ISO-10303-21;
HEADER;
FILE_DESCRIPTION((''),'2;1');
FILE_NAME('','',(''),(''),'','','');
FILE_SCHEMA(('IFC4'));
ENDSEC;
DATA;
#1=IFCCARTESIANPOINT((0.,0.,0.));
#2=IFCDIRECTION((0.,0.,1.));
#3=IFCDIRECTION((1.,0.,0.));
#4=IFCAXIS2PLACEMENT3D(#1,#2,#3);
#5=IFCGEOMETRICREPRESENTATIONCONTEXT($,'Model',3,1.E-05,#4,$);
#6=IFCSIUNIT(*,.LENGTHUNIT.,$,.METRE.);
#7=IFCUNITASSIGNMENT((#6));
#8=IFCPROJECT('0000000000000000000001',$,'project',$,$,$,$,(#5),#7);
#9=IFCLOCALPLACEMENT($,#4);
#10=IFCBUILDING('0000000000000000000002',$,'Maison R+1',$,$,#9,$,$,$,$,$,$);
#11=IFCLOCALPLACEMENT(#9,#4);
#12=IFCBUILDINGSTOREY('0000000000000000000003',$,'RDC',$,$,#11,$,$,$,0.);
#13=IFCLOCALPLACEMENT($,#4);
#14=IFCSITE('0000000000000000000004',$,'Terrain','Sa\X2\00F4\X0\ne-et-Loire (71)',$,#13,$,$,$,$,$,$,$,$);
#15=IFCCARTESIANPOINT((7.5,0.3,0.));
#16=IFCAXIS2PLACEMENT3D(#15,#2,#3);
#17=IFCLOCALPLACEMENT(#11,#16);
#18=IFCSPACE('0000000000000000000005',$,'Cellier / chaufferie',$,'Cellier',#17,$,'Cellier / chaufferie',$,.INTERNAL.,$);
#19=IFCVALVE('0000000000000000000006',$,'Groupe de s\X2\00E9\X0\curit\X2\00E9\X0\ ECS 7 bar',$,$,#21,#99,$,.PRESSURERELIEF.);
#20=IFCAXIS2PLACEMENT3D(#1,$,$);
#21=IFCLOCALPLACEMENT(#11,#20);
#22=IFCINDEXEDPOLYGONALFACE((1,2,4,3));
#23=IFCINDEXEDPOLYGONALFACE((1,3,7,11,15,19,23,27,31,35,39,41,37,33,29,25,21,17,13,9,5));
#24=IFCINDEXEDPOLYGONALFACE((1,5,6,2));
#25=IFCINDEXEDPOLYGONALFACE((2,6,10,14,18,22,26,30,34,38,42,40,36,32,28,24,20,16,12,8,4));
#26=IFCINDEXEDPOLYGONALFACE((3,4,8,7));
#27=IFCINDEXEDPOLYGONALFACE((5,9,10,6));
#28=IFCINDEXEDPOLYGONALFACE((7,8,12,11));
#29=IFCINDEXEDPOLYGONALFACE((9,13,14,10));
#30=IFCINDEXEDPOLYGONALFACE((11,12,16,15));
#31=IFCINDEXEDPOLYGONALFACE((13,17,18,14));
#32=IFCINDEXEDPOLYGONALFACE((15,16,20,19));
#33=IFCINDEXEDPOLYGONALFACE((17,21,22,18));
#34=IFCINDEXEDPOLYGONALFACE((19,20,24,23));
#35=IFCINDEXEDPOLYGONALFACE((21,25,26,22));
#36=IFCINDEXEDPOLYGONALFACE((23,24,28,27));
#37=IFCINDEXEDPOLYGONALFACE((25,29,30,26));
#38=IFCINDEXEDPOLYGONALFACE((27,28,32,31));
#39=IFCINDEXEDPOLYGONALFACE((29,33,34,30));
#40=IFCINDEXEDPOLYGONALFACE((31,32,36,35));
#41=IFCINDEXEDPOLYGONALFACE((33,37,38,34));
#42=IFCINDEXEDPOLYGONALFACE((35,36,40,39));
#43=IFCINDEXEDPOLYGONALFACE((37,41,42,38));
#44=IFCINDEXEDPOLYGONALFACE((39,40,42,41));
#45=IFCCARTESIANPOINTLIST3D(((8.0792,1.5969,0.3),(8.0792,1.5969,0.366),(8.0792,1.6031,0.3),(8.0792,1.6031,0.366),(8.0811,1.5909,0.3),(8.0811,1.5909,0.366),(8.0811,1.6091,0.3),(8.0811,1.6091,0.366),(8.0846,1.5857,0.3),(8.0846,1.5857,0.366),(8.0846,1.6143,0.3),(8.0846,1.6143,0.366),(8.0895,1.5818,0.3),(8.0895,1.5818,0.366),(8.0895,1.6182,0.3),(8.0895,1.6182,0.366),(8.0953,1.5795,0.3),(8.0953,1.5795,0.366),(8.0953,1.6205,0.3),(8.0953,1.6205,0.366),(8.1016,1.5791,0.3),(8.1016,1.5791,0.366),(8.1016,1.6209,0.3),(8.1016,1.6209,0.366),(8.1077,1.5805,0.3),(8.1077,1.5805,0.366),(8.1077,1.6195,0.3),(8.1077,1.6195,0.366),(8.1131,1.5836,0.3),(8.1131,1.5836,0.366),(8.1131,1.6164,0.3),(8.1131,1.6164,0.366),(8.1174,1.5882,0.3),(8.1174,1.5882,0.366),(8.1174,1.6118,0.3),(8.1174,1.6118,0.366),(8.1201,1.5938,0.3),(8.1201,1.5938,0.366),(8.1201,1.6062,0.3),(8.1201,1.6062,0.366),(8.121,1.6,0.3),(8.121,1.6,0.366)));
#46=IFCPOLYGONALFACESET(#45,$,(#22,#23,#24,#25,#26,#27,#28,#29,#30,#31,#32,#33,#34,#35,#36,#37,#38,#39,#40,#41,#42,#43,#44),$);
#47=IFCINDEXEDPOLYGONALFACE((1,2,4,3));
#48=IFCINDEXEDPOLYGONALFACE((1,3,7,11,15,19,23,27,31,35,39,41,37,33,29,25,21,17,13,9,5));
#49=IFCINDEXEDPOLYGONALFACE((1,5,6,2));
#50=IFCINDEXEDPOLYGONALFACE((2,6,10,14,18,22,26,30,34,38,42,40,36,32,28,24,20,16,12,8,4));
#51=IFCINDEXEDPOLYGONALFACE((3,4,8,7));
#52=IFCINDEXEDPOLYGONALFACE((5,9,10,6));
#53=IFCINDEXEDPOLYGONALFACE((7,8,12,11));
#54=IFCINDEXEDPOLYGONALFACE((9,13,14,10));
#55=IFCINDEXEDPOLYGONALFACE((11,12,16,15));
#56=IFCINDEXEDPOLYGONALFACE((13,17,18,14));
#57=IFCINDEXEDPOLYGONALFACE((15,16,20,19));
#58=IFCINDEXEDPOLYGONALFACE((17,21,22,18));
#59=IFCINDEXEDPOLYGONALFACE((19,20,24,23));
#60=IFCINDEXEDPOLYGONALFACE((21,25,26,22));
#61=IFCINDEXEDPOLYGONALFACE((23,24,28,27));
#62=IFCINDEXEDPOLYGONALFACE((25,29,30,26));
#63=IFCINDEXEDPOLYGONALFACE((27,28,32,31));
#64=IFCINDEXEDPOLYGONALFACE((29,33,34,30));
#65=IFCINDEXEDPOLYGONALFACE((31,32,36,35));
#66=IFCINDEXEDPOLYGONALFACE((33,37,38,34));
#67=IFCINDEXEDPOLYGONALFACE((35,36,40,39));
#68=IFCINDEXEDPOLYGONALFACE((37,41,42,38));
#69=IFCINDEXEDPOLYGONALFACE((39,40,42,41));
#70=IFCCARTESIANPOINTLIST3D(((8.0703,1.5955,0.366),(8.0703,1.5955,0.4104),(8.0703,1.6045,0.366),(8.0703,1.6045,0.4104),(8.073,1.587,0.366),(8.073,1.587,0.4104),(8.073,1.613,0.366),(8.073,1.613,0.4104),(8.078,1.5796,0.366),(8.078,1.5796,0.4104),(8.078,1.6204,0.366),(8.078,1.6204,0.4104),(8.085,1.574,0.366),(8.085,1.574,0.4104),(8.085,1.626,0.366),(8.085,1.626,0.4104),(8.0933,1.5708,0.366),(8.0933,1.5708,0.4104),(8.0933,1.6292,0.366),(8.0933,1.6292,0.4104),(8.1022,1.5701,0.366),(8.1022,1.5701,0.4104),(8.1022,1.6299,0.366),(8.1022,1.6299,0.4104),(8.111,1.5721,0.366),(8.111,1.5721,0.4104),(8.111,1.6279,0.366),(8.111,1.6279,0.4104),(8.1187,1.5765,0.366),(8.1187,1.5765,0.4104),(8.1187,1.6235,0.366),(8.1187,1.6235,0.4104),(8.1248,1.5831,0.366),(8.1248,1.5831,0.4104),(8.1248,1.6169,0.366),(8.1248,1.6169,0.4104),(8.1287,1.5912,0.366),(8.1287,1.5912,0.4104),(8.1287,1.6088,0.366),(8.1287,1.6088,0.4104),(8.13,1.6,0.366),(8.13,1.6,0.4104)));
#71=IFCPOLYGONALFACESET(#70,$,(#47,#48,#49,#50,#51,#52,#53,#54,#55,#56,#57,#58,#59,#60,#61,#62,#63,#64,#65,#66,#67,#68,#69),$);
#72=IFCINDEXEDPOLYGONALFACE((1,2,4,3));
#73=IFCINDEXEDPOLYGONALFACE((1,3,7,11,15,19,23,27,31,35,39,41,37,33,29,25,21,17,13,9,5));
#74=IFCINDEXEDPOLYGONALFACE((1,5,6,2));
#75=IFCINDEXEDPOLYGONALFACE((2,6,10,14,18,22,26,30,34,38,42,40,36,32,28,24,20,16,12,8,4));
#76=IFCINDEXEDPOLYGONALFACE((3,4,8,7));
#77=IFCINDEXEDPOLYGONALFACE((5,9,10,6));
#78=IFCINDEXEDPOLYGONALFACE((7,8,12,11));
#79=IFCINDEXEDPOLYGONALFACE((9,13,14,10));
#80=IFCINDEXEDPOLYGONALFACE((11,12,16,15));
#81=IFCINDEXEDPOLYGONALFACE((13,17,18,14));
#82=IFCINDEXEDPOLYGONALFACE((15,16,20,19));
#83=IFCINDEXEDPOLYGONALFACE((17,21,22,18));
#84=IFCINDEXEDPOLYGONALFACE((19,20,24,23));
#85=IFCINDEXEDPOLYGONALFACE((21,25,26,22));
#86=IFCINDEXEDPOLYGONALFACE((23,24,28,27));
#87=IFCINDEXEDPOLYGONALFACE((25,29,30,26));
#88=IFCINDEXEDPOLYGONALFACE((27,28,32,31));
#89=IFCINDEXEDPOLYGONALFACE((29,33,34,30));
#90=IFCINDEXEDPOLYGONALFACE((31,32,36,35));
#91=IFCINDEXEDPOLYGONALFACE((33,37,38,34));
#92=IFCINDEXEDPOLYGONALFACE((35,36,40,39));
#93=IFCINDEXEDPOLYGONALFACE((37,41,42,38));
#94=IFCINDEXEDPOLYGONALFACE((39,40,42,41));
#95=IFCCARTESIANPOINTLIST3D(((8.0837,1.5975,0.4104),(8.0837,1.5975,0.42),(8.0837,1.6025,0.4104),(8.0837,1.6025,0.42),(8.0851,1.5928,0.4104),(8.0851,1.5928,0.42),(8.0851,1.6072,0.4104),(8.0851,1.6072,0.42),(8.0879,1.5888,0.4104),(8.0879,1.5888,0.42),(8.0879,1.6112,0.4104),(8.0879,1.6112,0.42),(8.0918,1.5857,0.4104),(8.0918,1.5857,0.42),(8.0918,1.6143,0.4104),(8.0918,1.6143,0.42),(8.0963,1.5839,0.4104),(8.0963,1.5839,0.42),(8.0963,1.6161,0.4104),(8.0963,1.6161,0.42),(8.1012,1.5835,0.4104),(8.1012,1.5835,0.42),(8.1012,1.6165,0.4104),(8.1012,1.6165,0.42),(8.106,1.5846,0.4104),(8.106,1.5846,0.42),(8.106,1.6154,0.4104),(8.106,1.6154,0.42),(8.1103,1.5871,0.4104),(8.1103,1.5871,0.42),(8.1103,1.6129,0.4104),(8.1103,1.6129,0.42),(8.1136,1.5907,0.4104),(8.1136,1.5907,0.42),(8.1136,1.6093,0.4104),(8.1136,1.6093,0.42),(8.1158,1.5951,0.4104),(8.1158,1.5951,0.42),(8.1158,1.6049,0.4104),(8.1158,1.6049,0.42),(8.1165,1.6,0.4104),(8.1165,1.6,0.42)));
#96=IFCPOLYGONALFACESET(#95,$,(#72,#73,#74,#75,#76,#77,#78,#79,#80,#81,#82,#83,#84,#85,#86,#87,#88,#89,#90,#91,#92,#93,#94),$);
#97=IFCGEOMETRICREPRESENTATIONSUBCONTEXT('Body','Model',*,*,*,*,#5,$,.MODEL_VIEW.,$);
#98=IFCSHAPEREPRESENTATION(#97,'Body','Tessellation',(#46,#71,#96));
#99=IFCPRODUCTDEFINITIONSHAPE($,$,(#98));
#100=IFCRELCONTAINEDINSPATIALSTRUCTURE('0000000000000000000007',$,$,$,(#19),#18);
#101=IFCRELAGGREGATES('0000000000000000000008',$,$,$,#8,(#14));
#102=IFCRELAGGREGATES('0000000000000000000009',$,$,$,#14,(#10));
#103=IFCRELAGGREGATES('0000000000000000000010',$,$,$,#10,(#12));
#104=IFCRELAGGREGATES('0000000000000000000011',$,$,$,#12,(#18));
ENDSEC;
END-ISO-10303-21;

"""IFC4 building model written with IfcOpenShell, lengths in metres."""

from ifc_helpers import new_model, si_unit, frame, origin_with_axes, place, context, subcontext, project, spatial, circle, extrude, element, save


model = new_model("IFC4")

# Units and contexts
model_context = context("Model", 3, precision=1e-05, world=origin_with_axes())
body_context = subcontext(model_context, "Body", "Model", "MODEL_VIEW")
ifc_project = project(units=[si_unit("LENGTHUNIT", "METRE")], contexts=[model_context])

# Site, building, storey
site_placement = place(None, origin_with_axes())
site = spatial("IfcSite", under=ifc_project, at=site_placement, Name="Terrain", Description="Saône-et-Loire (71)")
building_placement = place(None, origin_with_axes())
building = spatial("IfcBuilding", under=site, at=building_placement, Name="Maison R+1")
storey_placement = place(building_placement, origin_with_axes())
storey = spatial("IfcBuildingStorey", under=building, at=storey_placement, Name="RDC", Elevation=0.0)

# Shared definitions
space_1_placement = place(storey_placement, frame((7.5, 0.3, 0.0), z_axis=(0.0, 0.0, 1.0), x_axis=(1.0, 0.0, 0.0)))
space_1 = spatial("IfcSpace", under=storey, at=space_1_placement, Name="Cellier / chaufferie", ObjectType="Cellier", LongName="Cellier / chaufferie", PredefinedType="INTERNAL")

# Valve
valve_1_placement = place(space_1_placement, frame((0.6, 1.3, 0.3), z_axis=(0.0, 0.0, 1.0), x_axis=(1.0, 0.0, 0.0)))
element("IfcValve", 1, at=valve_1_placement, inside=space_1, Name="Groupe de sécurité ECS 7 bar", PredefinedType="PRESSURERELIEF", context=body_context, shape_type="SweptSolid", body=[
    extrude(circle(Radius=0.021), origin_with_axes(), (0.0, 0.0, 1.0), 0.066),
    extrude(circle(Radius=0.03), frame((0.0, 0.0, 0.066), z_axis=(0.0, 0.0, 1.0), x_axis=(1.0, 0.0, 0.0)), (0.0, 0.0, 1.0), 0.0444),
    extrude(circle(Radius=0.0165), frame((0.0, 0.0, 0.1104), z_axis=(0.0, 0.0, 1.0), x_axis=(1.0, 0.0, 0.0)), (0.0, 0.0, 1.0), 0.0096),
])

save(model, "model.ifc")
